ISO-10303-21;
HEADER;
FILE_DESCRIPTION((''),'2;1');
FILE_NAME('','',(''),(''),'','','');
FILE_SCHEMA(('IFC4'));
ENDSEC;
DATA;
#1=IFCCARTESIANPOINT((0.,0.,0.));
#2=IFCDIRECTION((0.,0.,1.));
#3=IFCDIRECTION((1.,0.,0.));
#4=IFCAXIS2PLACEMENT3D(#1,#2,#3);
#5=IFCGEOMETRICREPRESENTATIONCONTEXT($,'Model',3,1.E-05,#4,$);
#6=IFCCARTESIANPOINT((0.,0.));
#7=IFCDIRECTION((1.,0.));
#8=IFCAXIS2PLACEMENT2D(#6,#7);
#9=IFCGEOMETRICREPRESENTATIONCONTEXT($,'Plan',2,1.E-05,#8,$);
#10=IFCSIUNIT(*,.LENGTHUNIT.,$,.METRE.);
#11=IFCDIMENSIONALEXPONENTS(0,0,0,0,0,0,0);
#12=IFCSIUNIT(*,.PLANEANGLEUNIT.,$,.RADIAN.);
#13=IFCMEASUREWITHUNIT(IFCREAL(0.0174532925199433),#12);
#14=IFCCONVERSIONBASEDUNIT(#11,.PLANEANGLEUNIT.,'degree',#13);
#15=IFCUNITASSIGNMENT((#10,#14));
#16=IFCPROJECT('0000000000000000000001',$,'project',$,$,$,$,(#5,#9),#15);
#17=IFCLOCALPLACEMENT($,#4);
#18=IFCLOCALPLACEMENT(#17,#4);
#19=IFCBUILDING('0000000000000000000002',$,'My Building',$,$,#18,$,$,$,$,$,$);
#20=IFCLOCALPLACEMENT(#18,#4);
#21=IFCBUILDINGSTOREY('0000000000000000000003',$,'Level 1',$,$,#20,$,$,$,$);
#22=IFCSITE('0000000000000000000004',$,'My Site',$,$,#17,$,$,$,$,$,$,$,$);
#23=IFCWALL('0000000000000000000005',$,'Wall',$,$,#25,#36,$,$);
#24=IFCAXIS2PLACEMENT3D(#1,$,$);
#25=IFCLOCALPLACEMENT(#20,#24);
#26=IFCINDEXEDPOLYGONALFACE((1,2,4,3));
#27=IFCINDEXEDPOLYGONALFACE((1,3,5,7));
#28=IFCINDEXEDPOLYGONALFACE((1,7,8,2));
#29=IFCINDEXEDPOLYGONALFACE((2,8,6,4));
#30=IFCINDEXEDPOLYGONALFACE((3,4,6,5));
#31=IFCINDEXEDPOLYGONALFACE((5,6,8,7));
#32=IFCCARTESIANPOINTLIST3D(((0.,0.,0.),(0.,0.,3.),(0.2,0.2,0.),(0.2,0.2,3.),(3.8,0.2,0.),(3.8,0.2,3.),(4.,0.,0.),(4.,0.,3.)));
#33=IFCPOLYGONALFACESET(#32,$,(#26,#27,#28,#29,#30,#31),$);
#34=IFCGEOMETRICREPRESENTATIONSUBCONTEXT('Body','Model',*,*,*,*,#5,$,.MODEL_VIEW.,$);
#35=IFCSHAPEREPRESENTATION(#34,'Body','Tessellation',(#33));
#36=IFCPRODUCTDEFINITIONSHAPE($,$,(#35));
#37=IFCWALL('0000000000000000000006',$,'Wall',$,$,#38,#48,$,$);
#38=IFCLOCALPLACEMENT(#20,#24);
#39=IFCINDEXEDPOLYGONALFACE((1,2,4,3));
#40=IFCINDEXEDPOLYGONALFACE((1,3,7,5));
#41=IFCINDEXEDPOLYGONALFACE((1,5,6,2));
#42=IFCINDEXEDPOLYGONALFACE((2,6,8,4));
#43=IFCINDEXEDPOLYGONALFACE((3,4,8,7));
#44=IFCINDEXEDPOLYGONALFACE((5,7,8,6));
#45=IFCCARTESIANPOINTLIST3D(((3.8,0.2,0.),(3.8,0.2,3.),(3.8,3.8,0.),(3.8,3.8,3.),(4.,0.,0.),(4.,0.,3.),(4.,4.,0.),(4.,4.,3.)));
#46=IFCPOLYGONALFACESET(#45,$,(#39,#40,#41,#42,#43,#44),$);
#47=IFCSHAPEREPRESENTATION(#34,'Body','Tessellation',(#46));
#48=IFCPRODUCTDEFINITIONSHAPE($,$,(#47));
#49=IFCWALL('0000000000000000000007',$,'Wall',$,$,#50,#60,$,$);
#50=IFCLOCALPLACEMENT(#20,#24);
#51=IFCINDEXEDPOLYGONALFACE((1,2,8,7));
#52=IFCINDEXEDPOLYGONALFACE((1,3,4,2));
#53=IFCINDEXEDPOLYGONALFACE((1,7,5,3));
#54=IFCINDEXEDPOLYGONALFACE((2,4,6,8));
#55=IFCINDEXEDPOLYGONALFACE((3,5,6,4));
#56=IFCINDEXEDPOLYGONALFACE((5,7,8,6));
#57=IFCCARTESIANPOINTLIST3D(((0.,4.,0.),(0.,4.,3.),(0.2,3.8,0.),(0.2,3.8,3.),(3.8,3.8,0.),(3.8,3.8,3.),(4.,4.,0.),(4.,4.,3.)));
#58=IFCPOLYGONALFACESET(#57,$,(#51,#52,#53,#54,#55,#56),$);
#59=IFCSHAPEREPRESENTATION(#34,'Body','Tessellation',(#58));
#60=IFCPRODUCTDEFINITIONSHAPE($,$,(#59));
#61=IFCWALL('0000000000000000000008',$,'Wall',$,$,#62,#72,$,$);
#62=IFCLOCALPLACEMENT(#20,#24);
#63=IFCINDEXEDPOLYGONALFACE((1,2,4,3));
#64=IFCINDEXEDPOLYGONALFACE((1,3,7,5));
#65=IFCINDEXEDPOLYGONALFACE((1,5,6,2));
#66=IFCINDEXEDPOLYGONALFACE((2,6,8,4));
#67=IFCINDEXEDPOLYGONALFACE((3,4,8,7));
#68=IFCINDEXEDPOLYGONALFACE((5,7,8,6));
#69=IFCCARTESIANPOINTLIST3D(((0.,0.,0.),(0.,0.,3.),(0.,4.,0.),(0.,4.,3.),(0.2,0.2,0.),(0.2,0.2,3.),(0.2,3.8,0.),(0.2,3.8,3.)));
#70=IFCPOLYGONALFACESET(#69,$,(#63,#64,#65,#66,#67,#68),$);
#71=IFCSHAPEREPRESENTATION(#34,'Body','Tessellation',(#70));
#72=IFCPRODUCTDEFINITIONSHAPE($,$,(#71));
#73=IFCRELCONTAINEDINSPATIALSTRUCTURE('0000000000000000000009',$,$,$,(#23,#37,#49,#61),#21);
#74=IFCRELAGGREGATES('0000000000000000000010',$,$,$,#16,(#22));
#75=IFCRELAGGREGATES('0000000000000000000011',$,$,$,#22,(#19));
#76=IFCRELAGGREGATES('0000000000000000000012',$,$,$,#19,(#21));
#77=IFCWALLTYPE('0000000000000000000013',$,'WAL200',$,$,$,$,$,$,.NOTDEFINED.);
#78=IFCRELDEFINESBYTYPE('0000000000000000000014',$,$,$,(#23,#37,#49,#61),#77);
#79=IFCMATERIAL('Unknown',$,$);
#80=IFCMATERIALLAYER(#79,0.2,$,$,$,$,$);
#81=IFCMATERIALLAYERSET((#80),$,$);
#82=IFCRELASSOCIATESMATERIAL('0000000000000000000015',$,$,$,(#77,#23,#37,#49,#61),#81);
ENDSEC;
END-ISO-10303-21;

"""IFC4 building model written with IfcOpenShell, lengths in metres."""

from ifc_helpers import new_model, entity, si_unit, converted_unit, frame, origin_with_axes, origin_2d_with_axis, place, context, subcontext, project, spatial, line, indexed_curve, outline, extrude, material, layer, layer_set, layer_usage, type_object, element, save


model = new_model("IFC4")

# Units and contexts
model_context = context("Model", 3, precision=1e-05, world=origin_with_axes())
plan_context = context("Plan", 2, precision=1e-05, world=origin_2d_with_axis())
body_context = subcontext(model_context, "Body", "Model", "MODEL_VIEW")
ifc_project = project(units=[si_unit("LENGTHUNIT", "METRE"), converted_unit("PLANEANGLEUNIT", "degree", entity("IfcReal", 0.0174532925199433), si_unit("PLANEANGLEUNIT", "RADIAN"), dimensions=[0, 0, 0, 0, 0, 0, 0])], contexts=[model_context, plan_context])

# Site, building, storey
site_placement = place(None, origin_with_axes())
site = spatial("IfcSite", under=ifc_project, at=site_placement, Name="My Site")
building_placement = place(site_placement, origin_with_axes())
building = spatial("IfcBuilding", under=site, at=building_placement, Name="My Building")
storey_placement = place(building_placement, origin_with_axes())
storey = spatial("IfcBuildingStorey", under=building, at=storey_placement, Name="Level 1")

# Walls
ifc_material = material(Name="Unknown")
ifc_layer = layer(ifc_material, 0.2)
ifc_layer_set = layer_set([ifc_layer])
ifc_layer_usage_1 = layer_usage(ifc_layer_set, "AXIS2", "POSITIVE", 0.0)
wall_type = type_object("IfcWallType", Name="WAL200", PredefinedType="NOTDEFINED", material=ifc_layer_set)
wall_1_placement = place(storey_placement, frame((0.0, 0.0, 0.0), z_axis=(0.0, 0.0, 1.0), x_axis=(1.0, 0.0, 0.0)))
element("IfcWall", 1, at=wall_1_placement, inside=storey, type_object=wall_type, material=ifc_layer_usage_1, Name="Wall", context=body_context, shape_type="SweptSolid", body=[
    extrude(outline(indexed_curve([(0.0, 0.0), (0.2, 0.2), (3.8, 0.2), (4.0, 0.0)], segments=[line(1, 2, 3, 4, 1)])), origin_with_axes(), (0.0, 0.0, 1.0), 3.0),
])
ifc_layer_usage_2 = layer_usage(ifc_layer_set, "AXIS2", "POSITIVE", 0.0)
wall_2_placement = place(storey_placement, frame((4.0, 0.0, 0.0), z_axis=(0.0, 0.0, 1.0), x_axis=(0.0, 1.0, 0.0)))
element("IfcWall", 2, at=wall_2_placement, inside=storey, type_object=wall_type, material=ifc_layer_usage_2, Name="Wall", context=body_context, shape_type="SweptSolid", body=[
    extrude(outline(indexed_curve([(0.0, 0.0), (0.2, 0.2), (3.8, 0.2), (4.0, 0.0)], segments=[line(1, 2, 3, 4, 1)])), origin_with_axes(), (0.0, 0.0, 1.0), 3.0),
])
ifc_layer_usage_3 = layer_usage(ifc_layer_set, "AXIS2", "POSITIVE", 0.0)
wall_3_placement = place(storey_placement, frame((4.0, 4.0, 0.0), z_axis=(0.0, 0.0, 1.0), x_axis=(-1.0, 0.0, 0.0)))
element("IfcWall", 3, at=wall_3_placement, inside=storey, type_object=wall_type, material=ifc_layer_usage_3, Name="Wall", context=body_context, shape_type="SweptSolid", body=[
    extrude(outline(indexed_curve([(0.0, 0.0), (0.2, 0.2), (3.8, 0.2), (4.0, 0.0)], segments=[line(1, 2, 3, 4, 1)])), origin_with_axes(), (0.0, 0.0, 1.0), 3.0),
])
ifc_layer_usage_4 = layer_usage(ifc_layer_set, "AXIS2", "POSITIVE", 0.0)
wall_4_placement = place(storey_placement, frame((0.0, 4.0, 0.0), z_axis=(0.0, 0.0, 1.0), x_axis=(0.0, -1.0, 0.0)))
element("IfcWall", 4, at=wall_4_placement, inside=storey, type_object=wall_type, material=ifc_layer_usage_4, Name="Wall", context=body_context, shape_type="SweptSolid", body=[
    extrude(outline(indexed_curve([(0.0, 0.0), (0.2, 0.2), (3.8, 0.2), (4.0, 0.0)], segments=[line(1, 2, 3, 4, 1)])), origin_with_axes(), (0.0, 0.0, 1.0), 3.0),
])

save(model, "model.ifc")
